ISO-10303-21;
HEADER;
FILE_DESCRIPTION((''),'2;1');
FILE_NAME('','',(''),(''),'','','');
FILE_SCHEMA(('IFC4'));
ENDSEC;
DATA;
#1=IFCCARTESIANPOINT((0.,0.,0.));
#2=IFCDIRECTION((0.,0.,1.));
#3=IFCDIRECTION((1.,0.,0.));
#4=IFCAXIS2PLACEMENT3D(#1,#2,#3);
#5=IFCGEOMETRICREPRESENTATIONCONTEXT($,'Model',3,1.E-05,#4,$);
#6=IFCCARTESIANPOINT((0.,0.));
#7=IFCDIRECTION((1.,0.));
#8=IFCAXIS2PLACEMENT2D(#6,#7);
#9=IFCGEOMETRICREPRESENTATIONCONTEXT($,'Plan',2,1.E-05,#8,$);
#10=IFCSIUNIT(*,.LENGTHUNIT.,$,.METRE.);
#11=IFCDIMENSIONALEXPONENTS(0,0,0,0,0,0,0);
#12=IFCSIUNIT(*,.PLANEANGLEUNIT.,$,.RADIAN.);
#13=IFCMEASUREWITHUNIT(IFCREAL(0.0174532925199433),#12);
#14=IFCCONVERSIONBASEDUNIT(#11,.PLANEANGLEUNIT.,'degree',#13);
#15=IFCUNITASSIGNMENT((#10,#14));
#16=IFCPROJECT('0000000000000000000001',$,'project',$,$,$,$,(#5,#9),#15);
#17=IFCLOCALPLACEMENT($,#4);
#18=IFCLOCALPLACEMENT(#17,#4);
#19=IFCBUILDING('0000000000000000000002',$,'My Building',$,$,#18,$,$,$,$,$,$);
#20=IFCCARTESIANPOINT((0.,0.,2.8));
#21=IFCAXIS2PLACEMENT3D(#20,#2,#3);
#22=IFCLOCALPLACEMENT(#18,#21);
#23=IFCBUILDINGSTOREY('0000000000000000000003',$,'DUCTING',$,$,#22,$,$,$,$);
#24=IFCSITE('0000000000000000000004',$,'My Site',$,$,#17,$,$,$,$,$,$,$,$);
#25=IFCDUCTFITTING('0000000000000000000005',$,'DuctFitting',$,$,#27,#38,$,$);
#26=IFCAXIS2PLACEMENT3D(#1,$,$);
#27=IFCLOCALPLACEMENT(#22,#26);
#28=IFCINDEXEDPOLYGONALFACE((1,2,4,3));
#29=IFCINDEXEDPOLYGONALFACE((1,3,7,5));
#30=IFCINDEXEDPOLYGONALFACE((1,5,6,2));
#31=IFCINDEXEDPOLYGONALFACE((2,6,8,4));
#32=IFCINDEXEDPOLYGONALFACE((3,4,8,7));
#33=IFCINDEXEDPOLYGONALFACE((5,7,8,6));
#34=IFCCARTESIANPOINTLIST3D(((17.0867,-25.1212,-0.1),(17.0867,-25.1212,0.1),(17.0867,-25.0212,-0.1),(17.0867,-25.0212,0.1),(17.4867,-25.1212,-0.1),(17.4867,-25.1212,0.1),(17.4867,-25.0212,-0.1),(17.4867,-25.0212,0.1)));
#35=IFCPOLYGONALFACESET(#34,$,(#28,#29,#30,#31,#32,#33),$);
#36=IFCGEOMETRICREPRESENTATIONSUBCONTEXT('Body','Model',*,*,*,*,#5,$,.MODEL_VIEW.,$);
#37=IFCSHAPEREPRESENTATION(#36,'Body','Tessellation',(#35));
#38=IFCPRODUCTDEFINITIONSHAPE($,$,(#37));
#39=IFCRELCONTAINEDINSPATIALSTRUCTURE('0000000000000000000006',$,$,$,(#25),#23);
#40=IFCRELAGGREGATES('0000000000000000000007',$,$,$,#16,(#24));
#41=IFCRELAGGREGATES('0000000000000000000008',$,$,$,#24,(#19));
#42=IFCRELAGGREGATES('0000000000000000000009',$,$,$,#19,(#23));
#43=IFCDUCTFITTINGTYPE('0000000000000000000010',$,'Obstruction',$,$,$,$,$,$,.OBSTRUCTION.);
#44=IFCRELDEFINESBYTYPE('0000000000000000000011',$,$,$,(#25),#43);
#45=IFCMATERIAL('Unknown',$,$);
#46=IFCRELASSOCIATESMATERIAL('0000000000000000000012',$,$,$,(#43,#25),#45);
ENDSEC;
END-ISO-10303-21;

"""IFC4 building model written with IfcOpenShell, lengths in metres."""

from ifc_helpers import new_model, entity, si_unit, converted_unit, frame, origin_with_axes, origin_2d_with_axis, place, context, subcontext, project, spatial, rectangle, extrude, material, material_profile, profile_set, profile_usage, type_object, element, save


model = new_model("IFC4")

# Units and contexts
model_context = context("Model", 3, precision=1e-05, world=origin_with_axes())
plan_context = context("Plan", 2, precision=1e-05, world=origin_2d_with_axis())
body_context = subcontext(model_context, "Body", "Model", "MODEL_VIEW")
ifc_project = project(units=[si_unit("LENGTHUNIT", "METRE"), converted_unit("PLANEANGLEUNIT", "degree", entity("IfcReal", 0.0174532925199433), si_unit("PLANEANGLEUNIT", "RADIAN"), dimensions=[0, 0, 0, 0, 0, 0, 0])], contexts=[model_context, plan_context])

# Site, building, storey
site_placement = place(None, origin_with_axes())
site = spatial("IfcSite", under=ifc_project, at=site_placement, Name="My Site")
building_placement = place(site_placement, origin_with_axes())
building = spatial("IfcBuilding", under=site, at=building_placement, Name="My Building")
storey_placement = place(building_placement, frame((0.0, 0.0, 2.8), z_axis=(0.0, 0.0, 1.0), x_axis=(1.0, 0.0, 0.0)))
storey = spatial("IfcBuildingStorey", under=building, at=storey_placement, Name="DUCTING")

# Shared definitions
ifc_material = material(Name="Unknown")

# Duct fitting
ifc_material_profile_1 = material_profile(ifc_material, rectangle(XDim=0.4, YDim=0.2))
ifc_profile_set_1 = profile_set([ifc_material_profile_1])
duct_fitting_type_1 = type_object("IfcDuctFittingType", Name="Obstruction", PredefinedType="OBSTRUCTION", material=ifc_profile_set_1)
ifc_profile_usage_1 = profile_usage(ifc_profile_set_1, cardinal=5)
duct_fitting_1_placement = place(storey_placement, frame((17.2867, -25.1212, 0.0), z_axis=(0.0, 1.0, 0.0), x_axis=(-1.0, 0.0, 0.0)))
element("IfcDuctFitting", 1, at=duct_fitting_1_placement, inside=storey, type_object=duct_fitting_type_1, material=ifc_profile_usage_1, Name="DuctFitting", context=body_context, shape_type="SweptSolid", body=[
    extrude(rectangle(XDim=0.4, YDim=0.2), origin_with_axes(), (0.0, 0.0, 1.0), 0.1),
])

save(model, "model.ifc")
